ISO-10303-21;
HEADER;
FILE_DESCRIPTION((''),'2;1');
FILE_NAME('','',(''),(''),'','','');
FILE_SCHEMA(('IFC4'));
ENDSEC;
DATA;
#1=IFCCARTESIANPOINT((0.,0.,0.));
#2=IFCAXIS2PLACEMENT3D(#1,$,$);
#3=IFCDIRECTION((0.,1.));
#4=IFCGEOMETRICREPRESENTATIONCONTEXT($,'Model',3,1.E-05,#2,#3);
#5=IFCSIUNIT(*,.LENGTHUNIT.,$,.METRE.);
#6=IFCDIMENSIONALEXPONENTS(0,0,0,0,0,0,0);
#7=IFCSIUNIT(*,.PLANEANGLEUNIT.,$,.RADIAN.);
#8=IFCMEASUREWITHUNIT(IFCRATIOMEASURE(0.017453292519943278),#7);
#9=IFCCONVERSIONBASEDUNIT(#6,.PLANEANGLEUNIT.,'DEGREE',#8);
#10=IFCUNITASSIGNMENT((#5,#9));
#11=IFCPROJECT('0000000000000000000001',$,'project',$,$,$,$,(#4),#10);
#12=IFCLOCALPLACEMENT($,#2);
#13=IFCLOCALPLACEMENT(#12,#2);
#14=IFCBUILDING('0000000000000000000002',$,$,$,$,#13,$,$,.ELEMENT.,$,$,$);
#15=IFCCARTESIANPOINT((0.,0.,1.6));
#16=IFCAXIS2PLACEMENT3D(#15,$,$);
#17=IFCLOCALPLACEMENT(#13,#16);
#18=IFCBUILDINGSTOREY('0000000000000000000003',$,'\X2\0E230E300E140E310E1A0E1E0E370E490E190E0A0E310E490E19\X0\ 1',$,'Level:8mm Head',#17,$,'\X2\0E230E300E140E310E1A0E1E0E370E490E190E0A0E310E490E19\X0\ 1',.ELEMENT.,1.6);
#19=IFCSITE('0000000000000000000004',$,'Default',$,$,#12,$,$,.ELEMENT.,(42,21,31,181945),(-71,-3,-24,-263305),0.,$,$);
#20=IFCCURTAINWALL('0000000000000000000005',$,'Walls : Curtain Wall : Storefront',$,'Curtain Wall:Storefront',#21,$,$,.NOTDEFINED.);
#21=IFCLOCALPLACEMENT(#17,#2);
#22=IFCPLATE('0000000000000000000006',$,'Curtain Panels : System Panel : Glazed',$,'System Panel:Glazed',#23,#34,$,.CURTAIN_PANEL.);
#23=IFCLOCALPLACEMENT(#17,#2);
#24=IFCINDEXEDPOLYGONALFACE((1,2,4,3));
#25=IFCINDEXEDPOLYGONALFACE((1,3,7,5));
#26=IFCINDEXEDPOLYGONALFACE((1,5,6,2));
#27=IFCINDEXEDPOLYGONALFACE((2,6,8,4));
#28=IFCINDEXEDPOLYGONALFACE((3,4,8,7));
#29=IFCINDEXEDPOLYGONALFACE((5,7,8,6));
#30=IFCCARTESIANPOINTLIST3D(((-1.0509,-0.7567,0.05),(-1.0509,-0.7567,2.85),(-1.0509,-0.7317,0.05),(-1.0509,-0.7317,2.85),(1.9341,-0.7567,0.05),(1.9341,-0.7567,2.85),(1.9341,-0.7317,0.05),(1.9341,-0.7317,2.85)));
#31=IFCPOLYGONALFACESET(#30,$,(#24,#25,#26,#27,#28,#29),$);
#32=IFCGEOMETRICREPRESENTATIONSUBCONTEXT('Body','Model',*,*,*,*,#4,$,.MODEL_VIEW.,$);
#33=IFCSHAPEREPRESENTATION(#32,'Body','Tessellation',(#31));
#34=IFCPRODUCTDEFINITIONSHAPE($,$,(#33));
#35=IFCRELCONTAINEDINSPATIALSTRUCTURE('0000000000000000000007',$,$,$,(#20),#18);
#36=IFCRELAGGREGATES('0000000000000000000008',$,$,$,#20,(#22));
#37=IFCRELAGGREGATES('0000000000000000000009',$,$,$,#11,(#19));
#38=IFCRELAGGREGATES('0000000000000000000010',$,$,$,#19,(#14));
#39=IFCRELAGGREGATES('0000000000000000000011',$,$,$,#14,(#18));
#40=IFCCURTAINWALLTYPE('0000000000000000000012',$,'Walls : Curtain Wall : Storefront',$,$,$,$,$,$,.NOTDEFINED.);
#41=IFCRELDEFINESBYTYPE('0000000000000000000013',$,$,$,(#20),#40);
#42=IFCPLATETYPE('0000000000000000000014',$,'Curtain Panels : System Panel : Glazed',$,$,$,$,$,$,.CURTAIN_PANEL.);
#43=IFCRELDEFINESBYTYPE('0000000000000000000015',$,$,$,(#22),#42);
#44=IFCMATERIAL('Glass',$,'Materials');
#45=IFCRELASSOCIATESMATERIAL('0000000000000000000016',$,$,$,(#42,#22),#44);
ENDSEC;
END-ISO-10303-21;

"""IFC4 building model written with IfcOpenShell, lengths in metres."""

from ifc_helpers import new_model, entity, si_unit, converted_unit, direction, frame, frame_2d, origin, place, context, subcontext, project, spatial, rectangle, extrude, source, transform, mapped, material, type_object, type_shapes, element, aggregate, save


model = new_model("IFC4")

# Units and contexts
model_context = context("Model", 3, precision=1e-05, world=origin(), true_north=direction((0.0, 1.0)))
body_context = subcontext(model_context, "Body", "Model", "MODEL_VIEW")
ifc_project = project(units=[si_unit("LENGTHUNIT", "METRE"), converted_unit("PLANEANGLEUNIT", "DEGREE", entity("IfcRatioMeasure", 0.017453292519943278), si_unit("PLANEANGLEUNIT", "RADIAN"), dimensions=[0, 0, 0, 0, 0, 0, 0])], contexts=[model_context])

# Site, building, storey
site_placement = place(None, origin())
site = spatial("IfcSite", under=ifc_project, at=site_placement, Name="Default", CompositionType="ELEMENT", RefLatitude=(42, 21, 31, 181945), RefLongitude=(-71, -3, -24, -263305), RefElevation=0.0)
building_placement = place(site_placement, origin())
building = spatial("IfcBuilding", under=site, at=building_placement, CompositionType="ELEMENT")
storey_placement = place(building_placement, frame((0.0, 0.0, 1.6)))
storey = spatial("IfcBuildingStorey", under=building, at=storey_placement, Name="ระดับพื้นชั้น 1", ObjectType="Level:8mm Head", LongName="ระดับพื้นชั้น 1", CompositionType="ELEMENT", Elevation=1.6)

# Shared definitions
curtain_wall_type = type_object("IfcCurtainWallType", Name="Walls : Curtain Wall : Storefront", PredefinedType="NOTDEFINED")

# Curtain wall
curtain_wall_1_placement = place(storey_placement, frame((0.0, 0.0, -1.6)))
curtain_wall_1 = element("IfcCurtainWall", 1, at=curtain_wall_1_placement, inside=storey, type_object=curtain_wall_type, Name="Walls : Curtain Wall : Storefront", ObjectType="Curtain Wall:Storefront", PredefinedType="NOTDEFINED")

# Plate
ifc_material_1 = material(Name="Glass", Category="Materials")
plate_type_1 = type_object("IfcPlateType", Name="Curtain Panels : System Panel : Glazed", PredefinedType="CURTAIN_PANEL", material=ifc_material_1)
shared_shape_1 = source(origin(), body_context, "Body", "SweptSolid", [
    extrude(rectangle(XDim=0.025, YDim=2.985, at=frame_2d((0.0, 0.0), x_axis=(1.0, 0.0))), frame((1.4925, 0.0125, 0.0), z_axis=(0.0, 0.0, 1.0), x_axis=(0.0, 1.0, 0.0)), (0.0, 0.0, 1.0), 2.8),
])
type_shapes(plate_type_1, [shared_shape_1])
plate_1_placement = place(curtain_wall_1_placement, frame((1.9341, -0.7317, 1.65), z_axis=(0.0, 0.0, 1.0), x_axis=(-1.0, 0.0, 0.0)))
plate_1 = element("IfcPlate", 2, at=plate_1_placement, type_object=plate_type_1, material=ifc_material_1, Name="Curtain Panels : System Panel : Glazed", ObjectType="System Panel:Glazed", PredefinedType="CURTAIN_PANEL", context=body_context, shape_type="MappedRepresentation", body=[
    mapped(shared_shape_1, transform((0.0, 0.0, 0.0), scale=1.0)),
])
aggregate(curtain_wall_1, [plate_1])

save(model, "model.ifc")
